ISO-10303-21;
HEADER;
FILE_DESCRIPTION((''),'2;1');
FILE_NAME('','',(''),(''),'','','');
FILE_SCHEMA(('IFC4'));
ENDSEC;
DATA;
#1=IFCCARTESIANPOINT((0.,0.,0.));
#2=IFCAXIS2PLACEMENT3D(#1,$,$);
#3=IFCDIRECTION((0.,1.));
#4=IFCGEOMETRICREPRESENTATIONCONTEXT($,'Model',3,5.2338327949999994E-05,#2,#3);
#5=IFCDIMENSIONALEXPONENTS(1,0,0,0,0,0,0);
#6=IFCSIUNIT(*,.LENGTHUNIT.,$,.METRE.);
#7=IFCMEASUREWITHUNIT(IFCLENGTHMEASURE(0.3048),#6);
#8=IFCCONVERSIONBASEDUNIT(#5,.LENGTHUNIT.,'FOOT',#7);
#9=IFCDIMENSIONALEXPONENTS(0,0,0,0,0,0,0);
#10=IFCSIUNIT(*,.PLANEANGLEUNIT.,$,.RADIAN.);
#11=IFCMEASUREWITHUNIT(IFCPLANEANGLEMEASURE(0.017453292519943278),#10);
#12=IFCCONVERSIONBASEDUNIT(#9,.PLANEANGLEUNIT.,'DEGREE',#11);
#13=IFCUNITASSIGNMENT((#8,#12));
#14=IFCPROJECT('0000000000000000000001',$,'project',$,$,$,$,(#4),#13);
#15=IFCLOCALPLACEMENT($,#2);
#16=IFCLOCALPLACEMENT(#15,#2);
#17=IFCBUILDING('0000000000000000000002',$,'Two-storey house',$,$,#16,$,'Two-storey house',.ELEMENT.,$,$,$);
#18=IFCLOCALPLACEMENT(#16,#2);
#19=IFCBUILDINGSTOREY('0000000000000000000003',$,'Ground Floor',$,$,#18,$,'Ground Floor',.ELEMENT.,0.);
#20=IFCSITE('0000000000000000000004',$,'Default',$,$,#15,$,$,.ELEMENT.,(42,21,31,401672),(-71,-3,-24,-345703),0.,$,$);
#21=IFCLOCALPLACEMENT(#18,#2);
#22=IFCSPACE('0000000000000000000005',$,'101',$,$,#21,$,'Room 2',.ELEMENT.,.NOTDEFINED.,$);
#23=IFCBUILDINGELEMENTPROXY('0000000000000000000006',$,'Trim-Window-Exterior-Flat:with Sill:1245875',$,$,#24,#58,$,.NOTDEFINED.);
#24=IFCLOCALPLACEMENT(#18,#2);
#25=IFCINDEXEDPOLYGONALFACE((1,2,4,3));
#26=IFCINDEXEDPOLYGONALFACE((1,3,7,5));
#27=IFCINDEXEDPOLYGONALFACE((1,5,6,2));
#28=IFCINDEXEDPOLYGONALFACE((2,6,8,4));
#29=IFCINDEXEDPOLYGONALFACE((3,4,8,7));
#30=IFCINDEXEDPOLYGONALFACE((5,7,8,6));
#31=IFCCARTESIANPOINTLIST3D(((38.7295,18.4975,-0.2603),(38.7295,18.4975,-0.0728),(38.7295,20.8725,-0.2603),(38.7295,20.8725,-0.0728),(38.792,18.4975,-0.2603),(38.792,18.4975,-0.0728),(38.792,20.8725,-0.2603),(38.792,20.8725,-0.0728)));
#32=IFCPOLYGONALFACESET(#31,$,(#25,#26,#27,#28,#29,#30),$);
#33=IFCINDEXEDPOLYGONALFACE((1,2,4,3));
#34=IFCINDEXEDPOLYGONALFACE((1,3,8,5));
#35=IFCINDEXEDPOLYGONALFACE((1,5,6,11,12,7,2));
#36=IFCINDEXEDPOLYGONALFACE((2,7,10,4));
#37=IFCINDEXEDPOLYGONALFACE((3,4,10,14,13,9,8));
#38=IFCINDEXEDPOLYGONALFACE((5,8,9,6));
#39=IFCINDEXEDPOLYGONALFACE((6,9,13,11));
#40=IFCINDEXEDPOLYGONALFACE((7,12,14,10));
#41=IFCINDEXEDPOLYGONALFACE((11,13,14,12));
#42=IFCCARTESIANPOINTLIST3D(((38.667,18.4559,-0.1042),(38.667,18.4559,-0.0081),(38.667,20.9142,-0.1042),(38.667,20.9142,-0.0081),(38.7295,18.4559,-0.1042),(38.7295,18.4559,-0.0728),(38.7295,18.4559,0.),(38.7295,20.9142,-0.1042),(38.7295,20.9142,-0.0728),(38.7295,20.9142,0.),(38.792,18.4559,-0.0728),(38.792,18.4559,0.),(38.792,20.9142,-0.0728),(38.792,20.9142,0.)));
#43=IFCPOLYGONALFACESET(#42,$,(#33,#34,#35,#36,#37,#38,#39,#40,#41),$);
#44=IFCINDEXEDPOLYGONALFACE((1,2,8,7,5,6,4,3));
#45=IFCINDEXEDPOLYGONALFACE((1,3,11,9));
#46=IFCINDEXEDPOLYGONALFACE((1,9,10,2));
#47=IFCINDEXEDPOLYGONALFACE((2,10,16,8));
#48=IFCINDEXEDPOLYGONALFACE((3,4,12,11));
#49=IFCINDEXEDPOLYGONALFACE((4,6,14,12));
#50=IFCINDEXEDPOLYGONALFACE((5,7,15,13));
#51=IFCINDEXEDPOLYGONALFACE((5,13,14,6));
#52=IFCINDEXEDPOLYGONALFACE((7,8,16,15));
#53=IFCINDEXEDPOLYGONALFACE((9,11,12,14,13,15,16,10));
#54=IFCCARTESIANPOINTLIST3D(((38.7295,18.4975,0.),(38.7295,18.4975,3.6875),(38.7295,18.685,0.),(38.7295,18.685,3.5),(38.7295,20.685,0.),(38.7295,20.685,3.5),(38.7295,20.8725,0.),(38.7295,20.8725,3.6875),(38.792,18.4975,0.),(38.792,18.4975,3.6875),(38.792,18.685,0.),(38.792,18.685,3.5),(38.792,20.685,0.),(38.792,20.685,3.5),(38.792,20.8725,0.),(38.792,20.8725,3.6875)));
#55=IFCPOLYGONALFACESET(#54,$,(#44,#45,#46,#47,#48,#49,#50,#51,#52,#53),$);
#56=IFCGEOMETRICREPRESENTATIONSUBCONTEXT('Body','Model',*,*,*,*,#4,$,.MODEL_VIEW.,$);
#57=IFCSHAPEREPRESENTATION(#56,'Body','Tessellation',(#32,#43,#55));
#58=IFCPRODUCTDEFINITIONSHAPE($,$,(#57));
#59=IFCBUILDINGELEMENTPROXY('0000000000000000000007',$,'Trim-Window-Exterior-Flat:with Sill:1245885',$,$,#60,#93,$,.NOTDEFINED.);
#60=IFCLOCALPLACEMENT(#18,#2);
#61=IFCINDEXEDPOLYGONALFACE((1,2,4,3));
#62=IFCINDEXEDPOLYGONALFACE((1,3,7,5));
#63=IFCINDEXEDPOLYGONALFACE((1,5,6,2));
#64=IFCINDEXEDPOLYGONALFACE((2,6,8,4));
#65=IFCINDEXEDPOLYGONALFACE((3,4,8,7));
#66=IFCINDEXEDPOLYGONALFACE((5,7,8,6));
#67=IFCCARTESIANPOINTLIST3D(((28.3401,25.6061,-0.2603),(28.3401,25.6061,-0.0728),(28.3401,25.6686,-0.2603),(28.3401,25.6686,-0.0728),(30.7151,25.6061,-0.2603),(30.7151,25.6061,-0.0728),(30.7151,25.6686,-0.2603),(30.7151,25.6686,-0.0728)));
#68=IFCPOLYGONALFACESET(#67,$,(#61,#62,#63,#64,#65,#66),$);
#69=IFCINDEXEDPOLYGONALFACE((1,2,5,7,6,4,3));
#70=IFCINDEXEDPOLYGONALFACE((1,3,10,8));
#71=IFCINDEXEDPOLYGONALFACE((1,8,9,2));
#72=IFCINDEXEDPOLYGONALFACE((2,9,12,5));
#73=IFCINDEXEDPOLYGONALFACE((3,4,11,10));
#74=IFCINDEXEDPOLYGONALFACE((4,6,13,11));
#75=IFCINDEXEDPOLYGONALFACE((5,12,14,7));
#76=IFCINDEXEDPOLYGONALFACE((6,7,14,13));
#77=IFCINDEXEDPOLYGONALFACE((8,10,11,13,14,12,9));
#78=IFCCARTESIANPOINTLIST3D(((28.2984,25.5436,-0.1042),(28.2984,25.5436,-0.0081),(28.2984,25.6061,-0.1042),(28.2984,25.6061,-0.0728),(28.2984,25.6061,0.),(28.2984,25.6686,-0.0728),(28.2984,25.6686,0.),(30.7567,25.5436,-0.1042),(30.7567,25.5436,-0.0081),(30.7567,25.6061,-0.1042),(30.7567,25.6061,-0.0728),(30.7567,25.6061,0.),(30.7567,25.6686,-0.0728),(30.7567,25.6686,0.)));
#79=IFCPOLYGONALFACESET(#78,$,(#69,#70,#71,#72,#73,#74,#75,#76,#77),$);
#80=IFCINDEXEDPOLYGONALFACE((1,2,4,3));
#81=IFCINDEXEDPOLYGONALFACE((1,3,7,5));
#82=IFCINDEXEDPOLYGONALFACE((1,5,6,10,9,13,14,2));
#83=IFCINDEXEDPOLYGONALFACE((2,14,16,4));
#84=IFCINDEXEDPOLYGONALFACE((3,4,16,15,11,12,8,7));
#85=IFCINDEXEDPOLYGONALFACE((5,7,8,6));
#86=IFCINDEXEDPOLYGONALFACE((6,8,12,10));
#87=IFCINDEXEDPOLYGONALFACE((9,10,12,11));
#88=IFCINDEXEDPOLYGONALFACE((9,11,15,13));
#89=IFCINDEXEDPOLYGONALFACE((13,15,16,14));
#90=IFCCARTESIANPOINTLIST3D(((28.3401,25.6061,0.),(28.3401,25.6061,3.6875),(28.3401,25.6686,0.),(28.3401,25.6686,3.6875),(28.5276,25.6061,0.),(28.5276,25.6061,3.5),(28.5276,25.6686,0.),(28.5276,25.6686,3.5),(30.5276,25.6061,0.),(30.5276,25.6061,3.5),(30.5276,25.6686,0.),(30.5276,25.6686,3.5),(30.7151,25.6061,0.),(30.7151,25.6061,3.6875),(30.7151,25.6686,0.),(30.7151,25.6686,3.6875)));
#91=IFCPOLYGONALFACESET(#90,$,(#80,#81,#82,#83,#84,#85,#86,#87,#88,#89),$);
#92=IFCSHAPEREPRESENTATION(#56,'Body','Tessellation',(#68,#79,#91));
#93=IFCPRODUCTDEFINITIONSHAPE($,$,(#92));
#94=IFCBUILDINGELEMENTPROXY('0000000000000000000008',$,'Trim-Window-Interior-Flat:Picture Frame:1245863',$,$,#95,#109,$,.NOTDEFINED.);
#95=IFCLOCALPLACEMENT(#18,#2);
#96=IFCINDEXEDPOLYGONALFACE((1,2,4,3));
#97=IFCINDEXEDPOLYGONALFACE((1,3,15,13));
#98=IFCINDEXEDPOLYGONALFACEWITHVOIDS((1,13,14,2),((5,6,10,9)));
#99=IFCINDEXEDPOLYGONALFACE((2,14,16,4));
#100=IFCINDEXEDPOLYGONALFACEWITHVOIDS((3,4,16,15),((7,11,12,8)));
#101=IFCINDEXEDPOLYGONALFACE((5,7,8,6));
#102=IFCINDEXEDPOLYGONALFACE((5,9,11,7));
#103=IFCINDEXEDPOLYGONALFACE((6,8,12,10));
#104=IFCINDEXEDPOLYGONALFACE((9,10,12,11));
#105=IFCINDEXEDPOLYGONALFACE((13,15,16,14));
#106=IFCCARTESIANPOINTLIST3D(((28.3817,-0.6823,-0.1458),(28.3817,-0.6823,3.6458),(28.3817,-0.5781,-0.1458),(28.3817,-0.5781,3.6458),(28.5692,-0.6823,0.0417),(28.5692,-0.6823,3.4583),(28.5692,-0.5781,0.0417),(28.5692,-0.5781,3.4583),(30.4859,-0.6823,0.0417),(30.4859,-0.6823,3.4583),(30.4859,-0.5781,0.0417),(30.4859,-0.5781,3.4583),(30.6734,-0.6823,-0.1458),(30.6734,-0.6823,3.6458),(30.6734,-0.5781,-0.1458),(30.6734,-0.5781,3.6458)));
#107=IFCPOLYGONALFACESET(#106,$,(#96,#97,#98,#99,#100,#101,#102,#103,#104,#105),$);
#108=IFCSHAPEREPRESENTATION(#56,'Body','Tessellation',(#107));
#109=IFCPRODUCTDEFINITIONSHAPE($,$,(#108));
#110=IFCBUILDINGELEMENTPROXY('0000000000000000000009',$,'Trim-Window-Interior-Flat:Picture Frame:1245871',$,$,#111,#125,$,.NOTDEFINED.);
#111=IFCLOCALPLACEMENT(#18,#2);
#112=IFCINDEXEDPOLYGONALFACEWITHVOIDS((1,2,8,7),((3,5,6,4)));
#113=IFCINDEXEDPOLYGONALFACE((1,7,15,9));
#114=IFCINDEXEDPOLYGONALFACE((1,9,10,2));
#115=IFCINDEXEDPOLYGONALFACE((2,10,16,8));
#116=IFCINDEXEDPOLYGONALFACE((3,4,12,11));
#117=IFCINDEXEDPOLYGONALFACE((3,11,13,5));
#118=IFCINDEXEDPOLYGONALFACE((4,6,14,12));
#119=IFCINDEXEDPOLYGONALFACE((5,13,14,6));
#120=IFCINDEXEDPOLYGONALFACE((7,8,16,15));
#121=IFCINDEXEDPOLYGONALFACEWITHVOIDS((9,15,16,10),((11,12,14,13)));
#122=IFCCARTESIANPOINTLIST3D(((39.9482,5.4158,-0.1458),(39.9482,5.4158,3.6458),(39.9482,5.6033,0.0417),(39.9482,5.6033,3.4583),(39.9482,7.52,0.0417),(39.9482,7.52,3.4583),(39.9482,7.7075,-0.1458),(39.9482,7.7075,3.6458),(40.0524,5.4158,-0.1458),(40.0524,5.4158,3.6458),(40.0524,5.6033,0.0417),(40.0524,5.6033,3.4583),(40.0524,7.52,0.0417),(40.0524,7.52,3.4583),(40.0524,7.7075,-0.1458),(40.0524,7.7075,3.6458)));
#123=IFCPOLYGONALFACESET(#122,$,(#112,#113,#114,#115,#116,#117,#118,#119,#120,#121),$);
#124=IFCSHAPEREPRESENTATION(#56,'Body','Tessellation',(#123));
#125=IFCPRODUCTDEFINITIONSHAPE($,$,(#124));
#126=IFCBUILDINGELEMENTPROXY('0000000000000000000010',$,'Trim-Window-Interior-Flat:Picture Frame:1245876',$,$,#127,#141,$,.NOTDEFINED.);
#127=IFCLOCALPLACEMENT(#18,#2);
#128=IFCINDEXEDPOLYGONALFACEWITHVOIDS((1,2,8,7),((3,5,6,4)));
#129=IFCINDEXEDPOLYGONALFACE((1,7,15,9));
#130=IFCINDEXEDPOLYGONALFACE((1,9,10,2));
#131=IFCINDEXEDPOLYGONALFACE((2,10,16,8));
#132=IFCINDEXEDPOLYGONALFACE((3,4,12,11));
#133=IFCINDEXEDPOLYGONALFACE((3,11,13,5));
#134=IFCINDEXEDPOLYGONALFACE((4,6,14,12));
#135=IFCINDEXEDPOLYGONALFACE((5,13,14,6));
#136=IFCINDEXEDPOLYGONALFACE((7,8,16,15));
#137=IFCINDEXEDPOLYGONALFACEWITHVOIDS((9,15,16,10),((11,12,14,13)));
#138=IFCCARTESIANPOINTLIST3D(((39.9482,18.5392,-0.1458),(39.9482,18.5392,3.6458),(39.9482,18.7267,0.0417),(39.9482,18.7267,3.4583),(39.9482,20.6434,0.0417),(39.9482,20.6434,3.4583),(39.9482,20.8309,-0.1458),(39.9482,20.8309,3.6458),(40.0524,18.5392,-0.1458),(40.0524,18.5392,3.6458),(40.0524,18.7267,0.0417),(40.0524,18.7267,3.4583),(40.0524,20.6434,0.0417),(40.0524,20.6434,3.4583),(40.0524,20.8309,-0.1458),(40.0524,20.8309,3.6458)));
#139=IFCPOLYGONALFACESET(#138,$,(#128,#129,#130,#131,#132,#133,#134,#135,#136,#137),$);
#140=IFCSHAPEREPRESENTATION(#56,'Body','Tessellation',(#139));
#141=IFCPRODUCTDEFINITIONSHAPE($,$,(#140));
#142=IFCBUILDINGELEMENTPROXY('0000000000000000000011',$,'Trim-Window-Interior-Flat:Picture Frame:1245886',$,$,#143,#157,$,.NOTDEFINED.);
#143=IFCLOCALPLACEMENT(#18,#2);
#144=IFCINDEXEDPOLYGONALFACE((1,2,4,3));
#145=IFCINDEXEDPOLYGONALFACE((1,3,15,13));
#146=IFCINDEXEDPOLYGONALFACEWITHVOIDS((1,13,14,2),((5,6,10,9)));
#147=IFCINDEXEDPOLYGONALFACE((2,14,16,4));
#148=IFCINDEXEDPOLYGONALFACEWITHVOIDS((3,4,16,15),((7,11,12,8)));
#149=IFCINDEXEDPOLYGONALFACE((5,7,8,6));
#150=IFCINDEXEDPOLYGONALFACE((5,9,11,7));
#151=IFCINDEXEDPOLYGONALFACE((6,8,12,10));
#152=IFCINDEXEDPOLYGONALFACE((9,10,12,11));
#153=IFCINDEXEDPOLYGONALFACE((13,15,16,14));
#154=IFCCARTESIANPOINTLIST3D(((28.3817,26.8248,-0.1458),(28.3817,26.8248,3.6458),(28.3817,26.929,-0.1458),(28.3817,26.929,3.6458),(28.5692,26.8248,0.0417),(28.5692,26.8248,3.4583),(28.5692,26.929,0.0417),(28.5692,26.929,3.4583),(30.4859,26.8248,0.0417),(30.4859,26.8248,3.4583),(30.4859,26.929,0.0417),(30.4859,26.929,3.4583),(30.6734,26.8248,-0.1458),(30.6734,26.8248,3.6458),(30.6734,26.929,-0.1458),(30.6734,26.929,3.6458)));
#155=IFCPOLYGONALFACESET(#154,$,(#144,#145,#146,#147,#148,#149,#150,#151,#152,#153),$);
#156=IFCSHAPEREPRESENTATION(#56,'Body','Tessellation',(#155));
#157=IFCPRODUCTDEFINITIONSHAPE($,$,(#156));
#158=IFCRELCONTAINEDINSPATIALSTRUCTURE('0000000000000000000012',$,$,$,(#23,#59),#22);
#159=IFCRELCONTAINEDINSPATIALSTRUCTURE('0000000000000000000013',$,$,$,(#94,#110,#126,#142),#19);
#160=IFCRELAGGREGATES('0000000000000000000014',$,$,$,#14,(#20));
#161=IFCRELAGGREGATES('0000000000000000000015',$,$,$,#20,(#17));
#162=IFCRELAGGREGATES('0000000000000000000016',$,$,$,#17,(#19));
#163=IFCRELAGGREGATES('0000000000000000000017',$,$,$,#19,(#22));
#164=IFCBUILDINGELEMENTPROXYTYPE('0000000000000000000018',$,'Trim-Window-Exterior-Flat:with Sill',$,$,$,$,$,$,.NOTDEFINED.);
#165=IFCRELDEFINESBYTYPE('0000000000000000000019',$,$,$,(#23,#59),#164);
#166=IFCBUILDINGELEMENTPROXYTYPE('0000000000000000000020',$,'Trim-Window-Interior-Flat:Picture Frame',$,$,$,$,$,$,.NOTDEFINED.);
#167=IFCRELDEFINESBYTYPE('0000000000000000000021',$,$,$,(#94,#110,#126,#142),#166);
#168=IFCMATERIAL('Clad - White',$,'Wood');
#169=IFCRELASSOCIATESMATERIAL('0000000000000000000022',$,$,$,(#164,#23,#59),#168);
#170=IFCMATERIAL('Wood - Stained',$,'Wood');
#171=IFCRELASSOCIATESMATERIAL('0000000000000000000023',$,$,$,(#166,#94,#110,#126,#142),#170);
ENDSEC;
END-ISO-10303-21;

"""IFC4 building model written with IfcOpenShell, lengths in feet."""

from ifc_helpers import new_model, entity, si_unit, converted_unit, direction, frame, origin, place, context, subcontext, project, spatial, indexed_curve, outline, extrude, source, transform, mapped, material, type_object, type_shapes, element, save


model = new_model("IFC4")

# Units and contexts
model_context = context("Model", 3, precision=5.2338327949999994e-05, world=origin(), true_north=direction((0.0, 1.0)))
body_context = subcontext(model_context, "Body", "Model", "MODEL_VIEW")
ifc_project = project(units=[converted_unit("LENGTHUNIT", "FOOT", entity("IfcLengthMeasure", 0.3048), si_unit("LENGTHUNIT", "METRE"), dimensions=[1, 0, 0, 0, 0, 0, 0]), converted_unit("PLANEANGLEUNIT", "DEGREE", entity("IfcPlaneAngleMeasure", 0.017453292519943278), si_unit("PLANEANGLEUNIT", "RADIAN"), dimensions=[0, 0, 0, 0, 0, 0, 0])], contexts=[model_context])

# Site, building, storey
site_placement = place(None, origin())
site = spatial("IfcSite", under=ifc_project, at=site_placement, Name="Default", CompositionType="ELEMENT", RefLatitude=(42, 21, 31, 401672), RefLongitude=(-71, -3, -24, -345703), RefElevation=0.0)
building_placement = place(site_placement, origin())
building = spatial("IfcBuilding", under=site, at=building_placement, Name="Two-storey house", LongName="Two-storey house", CompositionType="ELEMENT")
storey_placement = place(building_placement, origin())
storey = spatial("IfcBuildingStorey", under=building, at=storey_placement, Name="Ground Floor", LongName="Ground Floor", CompositionType="ELEMENT", Elevation=0.0)

# Shared definitions
ifc_material_1 = material(Name="Wood - Stained", Category="Wood")

# Shared definitions
ifc_material_2 = material(Name="Clad - White", Category="Wood")

# Shared definitions
building_element_proxy_type_1 = type_object("IfcBuildingElementProxyType", Name="Trim-Window-Exterior-Flat:with Sill", PredefinedType="NOTDEFINED", material=ifc_material_2)
shared_shape_1 = source(origin(), body_context, "Body", "SweptSolid", [
    extrude(outline(indexed_curve([(-1.1875, -0.0938), (1.1875, -0.0938), (1.1875, 0.0938), (-1.1875, 0.0938), (-1.1875, -0.0938)], self_intersect=False)), frame((0.0, -3.6665, 0.0), z_axis=(0.0, 0.0, 1.0), x_axis=(-1.0, 0.0, 0.0)), (0.0, 0.0, 1.0), 0.0625),
    extrude(outline(indexed_curve([(-0.0625, -0.0525), (0.0, -0.0525), (0.0, -0.0211), (0.0625, -0.0211), (0.0625, 0.0517), (0.0, 0.0517), (-0.0625, 0.0436), (-0.0625, -0.0525)], self_intersect=False)), frame((-1.2292, -3.5517, 0.0625), z_axis=(1.0, 0.0, 0.0), x_axis=(0.0, 0.0, -1.0)), (0.0, 0.0, 1.0), 2.4583),
    extrude(outline(indexed_curve([(-1.8906, -1.1875), (1.7969, -1.1875), (1.7969, -1.0), (-1.7031, -1.0), (-1.7031, 1.0), (1.7969, 1.0), (1.7969, 1.1875), (-1.8906, 1.1875), (-1.8906, -1.1875)], self_intersect=False)), frame((0.0, -1.7031, 0.0), z_axis=(0.0, 0.0, 1.0), x_axis=(0.0, -1.0, 0.0)), (0.0, 0.0, 1.0), 0.0625),
])
type_shapes(building_element_proxy_type_1, [shared_shape_1])

# Shared definitions
space_1_placement = place(storey_placement, origin())
space_1 = spatial("IfcSpace", under=storey, at=space_1_placement, Name="101", LongName="Room 2", CompositionType="ELEMENT", PredefinedType="NOTDEFINED")

# Building element proxies
for number, where, z_axis, x_axis, name in (
    (1, (38.792, 19.685, 3.5), (-1.0, 0.0, 0.0), (0.0, -1.0, 0.0), "Trim-Window-Exterior-Flat:with Sill:1245875"),
    (2, (29.5276, 25.6686, 3.5), (0.0, -1.0, 0.0), (1.0, 0.0, 0.0), "Trim-Window-Exterior-Flat:with Sill:1245885"),
):
    element("IfcBuildingElementProxy", number, at=place(space_1_placement, frame(where, z_axis=z_axis, x_axis=x_axis)), inside=space_1, type_object=building_element_proxy_type_1, material=ifc_material_2, Name=name, PredefinedType="NOTDEFINED", context=body_context, shape_type="MappedRepresentation", body=[
        mapped(shared_shape_1, transform((0.0, 0.0, 0.0), scale=1.0)),
    ])
building_element_proxy_type_2 = type_object("IfcBuildingElementProxyType", Name="Trim-Window-Interior-Flat:Picture Frame", PredefinedType="NOTDEFINED", material=ifc_material_1)
shared_shape_2 = source(origin(), body_context, "Body", "SweptSolid", [
    extrude(outline(indexed_curve([(-1.1458, -1.8958), (1.1458, -1.8958), (1.1458, 1.8958), (-1.1458, 1.8958), (-1.1458, -1.8958)], self_intersect=False), holes=[indexed_curve([(-0.9583, -1.7083), (-0.9583, 1.7083), (0.9583, 1.7083), (0.9583, -1.7083), (-0.9583, -1.7083)], self_intersect=False)]), frame((0.0, -1.75, 0.0), z_axis=(0.0, 0.0, 1.0), x_axis=(-1.0, 0.0, 0.0)), (0.0, 0.0, 1.0), 0.1042),
])
type_shapes(building_element_proxy_type_2, [shared_shape_2])
for number, where, z_axis, x_axis, name in (
    (3, (29.5276, -0.5781, 3.5), (0.0, -1.0, 0.0), (1.0, 0.0, 0.0), "Trim-Window-Interior-Flat:Picture Frame:1245863"),
    (4, (39.9482, 6.5617, 3.5), (1.0, 0.0, 0.0), (0.0, 1.0, 0.0), "Trim-Window-Interior-Flat:Picture Frame:1245871"),
    (5, (39.9482, 19.685, 3.5), (1.0, 0.0, 0.0), (0.0, 1.0, 0.0), "Trim-Window-Interior-Flat:Picture Frame:1245876"),
    (6, (29.5276, 26.8248, 3.5), (0.0, 1.0, 0.0), (-1.0, 0.0, 0.0), "Trim-Window-Interior-Flat:Picture Frame:1245886"),
):
    element("IfcBuildingElementProxy", number, at=place(storey_placement, frame(where, z_axis=z_axis, x_axis=x_axis)), inside=storey, type_object=building_element_proxy_type_2, material=ifc_material_1, Name=name, PredefinedType="NOTDEFINED", context=body_context, shape_type="MappedRepresentation", body=[
        mapped(shared_shape_2, transform((0.0, 0.0, 0.0), scale=1.0)),
    ])

save(model, "model.ifc")
